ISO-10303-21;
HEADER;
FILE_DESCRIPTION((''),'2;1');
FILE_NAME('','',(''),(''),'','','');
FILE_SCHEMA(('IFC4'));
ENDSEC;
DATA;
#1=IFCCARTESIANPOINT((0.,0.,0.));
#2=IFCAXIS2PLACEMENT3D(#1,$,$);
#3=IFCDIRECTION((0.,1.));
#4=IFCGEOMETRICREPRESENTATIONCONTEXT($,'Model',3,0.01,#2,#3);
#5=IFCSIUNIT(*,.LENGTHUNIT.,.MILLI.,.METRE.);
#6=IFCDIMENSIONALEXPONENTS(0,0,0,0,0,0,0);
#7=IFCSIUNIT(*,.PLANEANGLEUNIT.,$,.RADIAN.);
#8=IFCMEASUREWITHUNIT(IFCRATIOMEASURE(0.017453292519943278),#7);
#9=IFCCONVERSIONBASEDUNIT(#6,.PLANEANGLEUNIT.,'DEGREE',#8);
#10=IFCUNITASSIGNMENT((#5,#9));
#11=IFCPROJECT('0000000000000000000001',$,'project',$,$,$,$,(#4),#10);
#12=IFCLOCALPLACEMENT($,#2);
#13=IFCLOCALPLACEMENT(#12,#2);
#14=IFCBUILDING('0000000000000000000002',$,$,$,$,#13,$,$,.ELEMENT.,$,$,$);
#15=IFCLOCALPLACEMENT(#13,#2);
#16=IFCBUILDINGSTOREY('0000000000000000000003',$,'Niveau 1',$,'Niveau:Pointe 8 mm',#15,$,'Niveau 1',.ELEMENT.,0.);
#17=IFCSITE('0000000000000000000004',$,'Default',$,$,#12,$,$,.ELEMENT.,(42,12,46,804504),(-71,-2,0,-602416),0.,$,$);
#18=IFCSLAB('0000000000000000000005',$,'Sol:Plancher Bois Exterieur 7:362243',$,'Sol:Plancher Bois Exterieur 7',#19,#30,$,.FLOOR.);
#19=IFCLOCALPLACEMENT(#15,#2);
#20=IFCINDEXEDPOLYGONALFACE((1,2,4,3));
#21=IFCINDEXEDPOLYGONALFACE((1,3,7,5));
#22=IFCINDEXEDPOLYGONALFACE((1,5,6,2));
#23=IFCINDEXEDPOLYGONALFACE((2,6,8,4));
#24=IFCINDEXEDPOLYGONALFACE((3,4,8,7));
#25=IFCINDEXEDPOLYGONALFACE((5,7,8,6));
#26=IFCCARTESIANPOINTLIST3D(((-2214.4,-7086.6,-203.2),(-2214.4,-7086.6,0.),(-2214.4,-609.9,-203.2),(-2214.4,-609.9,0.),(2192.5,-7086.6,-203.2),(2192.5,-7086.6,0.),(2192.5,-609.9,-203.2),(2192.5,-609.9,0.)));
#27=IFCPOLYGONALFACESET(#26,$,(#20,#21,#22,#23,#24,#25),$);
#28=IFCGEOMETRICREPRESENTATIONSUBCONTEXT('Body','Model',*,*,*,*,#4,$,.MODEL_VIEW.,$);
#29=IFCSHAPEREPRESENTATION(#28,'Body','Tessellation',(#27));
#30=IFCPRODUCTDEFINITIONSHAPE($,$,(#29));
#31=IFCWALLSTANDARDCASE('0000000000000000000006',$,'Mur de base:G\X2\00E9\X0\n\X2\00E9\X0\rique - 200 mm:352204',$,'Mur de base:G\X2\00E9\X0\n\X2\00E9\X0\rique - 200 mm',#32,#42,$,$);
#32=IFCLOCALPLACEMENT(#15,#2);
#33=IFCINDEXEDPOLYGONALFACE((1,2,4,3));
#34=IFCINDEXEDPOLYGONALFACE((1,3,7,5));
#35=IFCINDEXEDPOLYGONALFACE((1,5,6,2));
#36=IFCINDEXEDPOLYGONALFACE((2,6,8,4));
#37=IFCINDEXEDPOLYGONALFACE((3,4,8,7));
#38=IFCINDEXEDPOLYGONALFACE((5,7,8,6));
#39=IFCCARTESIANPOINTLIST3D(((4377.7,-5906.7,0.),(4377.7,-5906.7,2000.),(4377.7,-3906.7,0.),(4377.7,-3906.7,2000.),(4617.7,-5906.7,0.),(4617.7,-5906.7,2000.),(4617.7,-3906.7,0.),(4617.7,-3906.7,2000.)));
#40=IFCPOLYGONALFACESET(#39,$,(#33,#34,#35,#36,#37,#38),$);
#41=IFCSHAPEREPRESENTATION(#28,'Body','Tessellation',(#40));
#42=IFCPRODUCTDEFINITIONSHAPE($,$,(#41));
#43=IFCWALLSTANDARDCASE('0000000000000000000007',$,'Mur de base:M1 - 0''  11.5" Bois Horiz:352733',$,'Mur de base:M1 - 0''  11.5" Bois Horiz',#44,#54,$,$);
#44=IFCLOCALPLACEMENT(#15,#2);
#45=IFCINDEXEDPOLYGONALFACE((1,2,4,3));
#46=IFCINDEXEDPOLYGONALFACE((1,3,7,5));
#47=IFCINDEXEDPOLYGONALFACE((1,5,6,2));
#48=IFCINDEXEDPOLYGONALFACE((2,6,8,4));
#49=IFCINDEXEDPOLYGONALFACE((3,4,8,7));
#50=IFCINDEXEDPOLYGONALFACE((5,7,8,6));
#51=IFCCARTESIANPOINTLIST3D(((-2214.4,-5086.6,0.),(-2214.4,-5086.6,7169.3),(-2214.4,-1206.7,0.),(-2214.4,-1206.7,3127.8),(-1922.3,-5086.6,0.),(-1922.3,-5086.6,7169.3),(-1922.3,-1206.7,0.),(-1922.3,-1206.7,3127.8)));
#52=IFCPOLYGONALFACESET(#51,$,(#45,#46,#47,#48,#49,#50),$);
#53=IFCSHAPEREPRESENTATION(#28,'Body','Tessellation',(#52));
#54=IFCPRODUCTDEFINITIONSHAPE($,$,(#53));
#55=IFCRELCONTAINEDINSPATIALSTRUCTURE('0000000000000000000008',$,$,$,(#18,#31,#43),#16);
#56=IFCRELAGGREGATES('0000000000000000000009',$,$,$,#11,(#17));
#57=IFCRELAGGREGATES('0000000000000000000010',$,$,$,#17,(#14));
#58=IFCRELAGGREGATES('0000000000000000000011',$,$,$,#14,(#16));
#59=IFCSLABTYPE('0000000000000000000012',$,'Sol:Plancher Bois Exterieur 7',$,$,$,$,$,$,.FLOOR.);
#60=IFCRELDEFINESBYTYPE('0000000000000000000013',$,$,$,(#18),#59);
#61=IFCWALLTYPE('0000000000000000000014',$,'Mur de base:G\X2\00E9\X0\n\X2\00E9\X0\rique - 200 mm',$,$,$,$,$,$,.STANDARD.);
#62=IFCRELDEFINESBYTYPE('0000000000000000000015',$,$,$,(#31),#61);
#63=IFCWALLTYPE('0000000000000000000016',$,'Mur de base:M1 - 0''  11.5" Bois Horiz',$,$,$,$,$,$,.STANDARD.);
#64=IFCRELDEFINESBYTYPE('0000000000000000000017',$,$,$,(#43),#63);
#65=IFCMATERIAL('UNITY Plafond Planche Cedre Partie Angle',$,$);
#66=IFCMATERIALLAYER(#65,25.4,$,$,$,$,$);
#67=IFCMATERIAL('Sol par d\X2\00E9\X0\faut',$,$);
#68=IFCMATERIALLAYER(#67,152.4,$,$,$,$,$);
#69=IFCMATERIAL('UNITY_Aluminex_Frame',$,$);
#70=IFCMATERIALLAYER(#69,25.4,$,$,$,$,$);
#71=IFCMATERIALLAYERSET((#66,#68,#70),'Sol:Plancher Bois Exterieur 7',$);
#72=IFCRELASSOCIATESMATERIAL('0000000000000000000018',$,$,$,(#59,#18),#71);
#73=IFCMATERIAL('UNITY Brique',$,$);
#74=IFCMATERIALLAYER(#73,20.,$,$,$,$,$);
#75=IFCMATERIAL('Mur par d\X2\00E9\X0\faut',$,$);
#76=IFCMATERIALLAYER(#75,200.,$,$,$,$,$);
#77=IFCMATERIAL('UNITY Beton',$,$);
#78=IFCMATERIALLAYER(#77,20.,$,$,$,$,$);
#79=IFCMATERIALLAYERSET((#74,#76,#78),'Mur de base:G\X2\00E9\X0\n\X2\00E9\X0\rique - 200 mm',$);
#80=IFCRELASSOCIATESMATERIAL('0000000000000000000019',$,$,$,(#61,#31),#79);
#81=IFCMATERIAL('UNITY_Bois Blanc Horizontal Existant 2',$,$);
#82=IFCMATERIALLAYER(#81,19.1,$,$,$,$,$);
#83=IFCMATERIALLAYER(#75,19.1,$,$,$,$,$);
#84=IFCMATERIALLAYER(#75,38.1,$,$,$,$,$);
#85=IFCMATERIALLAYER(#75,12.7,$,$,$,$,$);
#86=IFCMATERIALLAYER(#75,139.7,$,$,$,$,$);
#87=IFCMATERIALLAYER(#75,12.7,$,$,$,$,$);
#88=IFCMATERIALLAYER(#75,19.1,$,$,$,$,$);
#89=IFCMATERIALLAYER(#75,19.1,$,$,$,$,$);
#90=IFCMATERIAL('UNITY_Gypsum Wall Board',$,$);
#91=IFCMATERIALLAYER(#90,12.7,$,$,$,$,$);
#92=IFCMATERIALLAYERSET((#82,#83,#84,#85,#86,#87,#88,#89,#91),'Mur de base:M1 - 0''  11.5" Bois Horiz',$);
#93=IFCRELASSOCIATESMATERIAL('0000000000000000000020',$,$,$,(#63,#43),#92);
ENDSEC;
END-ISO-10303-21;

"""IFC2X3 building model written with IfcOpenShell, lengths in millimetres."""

from ifc_helpers import new_model, entity, si_unit, converted_unit, direction, frame, frame_2d, origin, place, context, subcontext, project, spatial, polyline, rectangle, extrude, clip, bounded_halfspace, material, layer, layer_set, layer_usage, type_object, element, save


model = new_model("IFC2X3")

# Units and contexts
model_context = context("Model", 3, precision=0.01, world=origin(), true_north=direction((0.0, 1.0)))
body_context = subcontext(model_context, "Body", "Model", "MODEL_VIEW")
ifc_project = project(units=[si_unit("LENGTHUNIT", "METRE", prefix="MILLI"), converted_unit("PLANEANGLEUNIT", "DEGREE", entity("IfcRatioMeasure", 0.017453292519943278), si_unit("PLANEANGLEUNIT", "RADIAN"), dimensions=[0, 0, 0, 0, 0, 0, 0])], contexts=[model_context])

# Site, building, storey
site_placement = place(None, origin())
site = spatial("IfcSite", under=ifc_project, at=site_placement, Name="Default", CompositionType="ELEMENT", RefLatitude=(42, 12, 46, 804504), RefLongitude=(-71, -2, 0, -602416), RefElevation=0.0)
building_placement = place(site_placement, origin())
building = spatial("IfcBuilding", under=site, at=building_placement, CompositionType="ELEMENT")
storey_placement = place(building_placement, origin())
storey = spatial("IfcBuildingStorey", under=building, at=storey_placement, Name="Niveau 1", ObjectType="Niveau:Pointe 8 mm", LongName="Niveau 1", CompositionType="ELEMENT", Elevation=0.0)

# Slab
ifc_material_1 = material(Name="UNITY Plafond Planche Cedre Partie Angle")
ifc_layer_1 = layer(ifc_material_1, 25.4)
ifc_material_2 = material(Name="Sol par défaut")
ifc_layer_2 = layer(ifc_material_2, 152.4)
ifc_material_3 = material(Name="UNITY_Aluminex_Frame")
ifc_layer_3 = layer(ifc_material_3, 25.4)
ifc_layer_set_1 = layer_set([ifc_layer_1, ifc_layer_2, ifc_layer_3], Name="Sol:Plancher Bois Exterieur 7")
ifc_layer_usage_1 = layer_usage(ifc_layer_set_1, "AXIS3", "POSITIVE", 0.0)
slab_type = type_object("IfcSlabType", Name="Sol:Plancher Bois Exterieur 7", PredefinedType="FLOOR", material=ifc_layer_set_1)
slab_placement = place(storey_placement, origin())
element("IfcSlab", 1, at=slab_placement, inside=storey, type_object=slab_type, material=ifc_layer_usage_1, Name="Sol:Plancher Bois Exterieur 7:362243", ObjectType="Sol:Plancher Bois Exterieur 7", PredefinedType="FLOOR", context=body_context, shape_type="SweptSolid", body=[
    extrude(rectangle(XDim=6476.6, YDim=4406.9, at=frame_2d((0.0, 0.0), x_axis=(1.0, 0.0))), frame((-10.9, -3848.2, 0.0), z_axis=(0.0, 0.0, -1.0), x_axis=(0.0, 1.0, 0.0)), (0.0, 0.0, 1.0), 203.2),
])

# Wall
ifc_material_4 = material(Name="UNITY Brique")
ifc_layer_4 = layer(ifc_material_4, 20.0)
ifc_material_5 = material(Name="Mur par défaut")
ifc_layer_5 = layer(ifc_material_5, 200.0)
ifc_material_6 = material(Name="UNITY Beton")
ifc_layer_6 = layer(ifc_material_6, 20.0)
ifc_layer_set_2 = layer_set([ifc_layer_4, ifc_layer_5, ifc_layer_6], Name="Mur de base:Générique - 200 mm")
ifc_layer_usage_2 = layer_usage(ifc_layer_set_2, "AXIS2", "NEGATIVE", 120.0)
wall_type_1 = type_object("IfcWallType", Name="Mur de base:Générique - 200 mm", PredefinedType="STANDARD", material=ifc_layer_set_2)
wall_1_placement = place(storey_placement, frame((4497.7, -3906.7, 0.0), z_axis=(0.0, 0.0, 1.0), x_axis=(0.0, -1.0, 0.0)))
element("IfcWallStandardCase", 2, at=wall_1_placement, inside=storey, type_object=wall_type_1, material=ifc_layer_usage_2, Name="Mur de base:Générique - 200 mm:352204", ObjectType="Mur de base:Générique - 200 mm", context=body_context, shape_type="SweptSolid", body=[
    extrude(rectangle(XDim=2000.0, YDim=240.0, at=frame_2d((1000.0, 0.0), x_axis=(-1.0, 0.0))), origin(), (0.0, 0.0, 1.0), 2000.0),
])

# Shared definitions
ifc_material_7 = material(Name="UNITY_Bois Blanc Horizontal Existant 2")
ifc_layer_7 = layer(ifc_material_7, 19.1)
ifc_layer_8 = layer(ifc_material_5, 19.1)
ifc_layer_9 = layer(ifc_material_5, 38.1)
ifc_layer_10 = layer(ifc_material_5, 12.7)
ifc_layer_11 = layer(ifc_material_5, 139.7)
ifc_layer_12 = layer(ifc_material_5, 12.7)
ifc_layer_13 = layer(ifc_material_5, 19.1)
ifc_layer_14 = layer(ifc_material_5, 19.1)
ifc_material_8 = material(Name="UNITY_Gypsum Wall Board")
ifc_layer_15 = layer(ifc_material_8, 12.7)
ifc_layer_set_3 = layer_set([ifc_layer_7, ifc_layer_8, ifc_layer_9, ifc_layer_10, ifc_layer_11, ifc_layer_12, ifc_layer_13, ifc_layer_14, ifc_layer_15], Name="Mur de base:M1 - 0'  11.5\" Bois Horiz")
wall_type_2 = type_object("IfcWallType", Name="Mur de base:M1 - 0'  11.5\" Bois Horiz", PredefinedType="STANDARD", material=ifc_layer_set_3)

# Wall
ifc_layer_usage_3 = layer_usage(ifc_layer_set_3, "AXIS2", "NEGATIVE", 146.1)
wall_2_placement = place(storey_placement, frame((-2068.3, -5086.6, 0.0), z_axis=(0.0, 0.0, 1.0), x_axis=(0.0, 1.0, 0.0)))
element("IfcWallStandardCase", 3, at=wall_2_placement, inside=storey, type_object=wall_type_2, material=ifc_layer_usage_3, Name="Mur de base:M1 - 0'  11.5\" Bois Horiz:352733", ObjectType="Mur de base:M1 - 0'  11.5\" Bois Horiz", context=body_context, shape_type="Clipping", body=[
    clip(extrude(rectangle(XDim=3879.8, YDim=292.1, at=frame_2d((1939.9, 0.0), x_axis=(-1.0, 0.0))), origin(), (0.0, 0.0, 1.0), 7169.3), bounded_halfspace(frame((0.0, -146.0, 7169.3), z_axis=(0.721387, 0.0, 0.692532), x_axis=(0.0, 1.0, 0.0)), False, frame((0.0, -146.0, 7169.3)), polyline([(0.0, 0.0), (292.1, 0.0), (3879.8, 0.0), (3879.8, 292.1), (0.0, 292.1), (0.0, 0.0)]))),
])

save(model, "model.ifc")
